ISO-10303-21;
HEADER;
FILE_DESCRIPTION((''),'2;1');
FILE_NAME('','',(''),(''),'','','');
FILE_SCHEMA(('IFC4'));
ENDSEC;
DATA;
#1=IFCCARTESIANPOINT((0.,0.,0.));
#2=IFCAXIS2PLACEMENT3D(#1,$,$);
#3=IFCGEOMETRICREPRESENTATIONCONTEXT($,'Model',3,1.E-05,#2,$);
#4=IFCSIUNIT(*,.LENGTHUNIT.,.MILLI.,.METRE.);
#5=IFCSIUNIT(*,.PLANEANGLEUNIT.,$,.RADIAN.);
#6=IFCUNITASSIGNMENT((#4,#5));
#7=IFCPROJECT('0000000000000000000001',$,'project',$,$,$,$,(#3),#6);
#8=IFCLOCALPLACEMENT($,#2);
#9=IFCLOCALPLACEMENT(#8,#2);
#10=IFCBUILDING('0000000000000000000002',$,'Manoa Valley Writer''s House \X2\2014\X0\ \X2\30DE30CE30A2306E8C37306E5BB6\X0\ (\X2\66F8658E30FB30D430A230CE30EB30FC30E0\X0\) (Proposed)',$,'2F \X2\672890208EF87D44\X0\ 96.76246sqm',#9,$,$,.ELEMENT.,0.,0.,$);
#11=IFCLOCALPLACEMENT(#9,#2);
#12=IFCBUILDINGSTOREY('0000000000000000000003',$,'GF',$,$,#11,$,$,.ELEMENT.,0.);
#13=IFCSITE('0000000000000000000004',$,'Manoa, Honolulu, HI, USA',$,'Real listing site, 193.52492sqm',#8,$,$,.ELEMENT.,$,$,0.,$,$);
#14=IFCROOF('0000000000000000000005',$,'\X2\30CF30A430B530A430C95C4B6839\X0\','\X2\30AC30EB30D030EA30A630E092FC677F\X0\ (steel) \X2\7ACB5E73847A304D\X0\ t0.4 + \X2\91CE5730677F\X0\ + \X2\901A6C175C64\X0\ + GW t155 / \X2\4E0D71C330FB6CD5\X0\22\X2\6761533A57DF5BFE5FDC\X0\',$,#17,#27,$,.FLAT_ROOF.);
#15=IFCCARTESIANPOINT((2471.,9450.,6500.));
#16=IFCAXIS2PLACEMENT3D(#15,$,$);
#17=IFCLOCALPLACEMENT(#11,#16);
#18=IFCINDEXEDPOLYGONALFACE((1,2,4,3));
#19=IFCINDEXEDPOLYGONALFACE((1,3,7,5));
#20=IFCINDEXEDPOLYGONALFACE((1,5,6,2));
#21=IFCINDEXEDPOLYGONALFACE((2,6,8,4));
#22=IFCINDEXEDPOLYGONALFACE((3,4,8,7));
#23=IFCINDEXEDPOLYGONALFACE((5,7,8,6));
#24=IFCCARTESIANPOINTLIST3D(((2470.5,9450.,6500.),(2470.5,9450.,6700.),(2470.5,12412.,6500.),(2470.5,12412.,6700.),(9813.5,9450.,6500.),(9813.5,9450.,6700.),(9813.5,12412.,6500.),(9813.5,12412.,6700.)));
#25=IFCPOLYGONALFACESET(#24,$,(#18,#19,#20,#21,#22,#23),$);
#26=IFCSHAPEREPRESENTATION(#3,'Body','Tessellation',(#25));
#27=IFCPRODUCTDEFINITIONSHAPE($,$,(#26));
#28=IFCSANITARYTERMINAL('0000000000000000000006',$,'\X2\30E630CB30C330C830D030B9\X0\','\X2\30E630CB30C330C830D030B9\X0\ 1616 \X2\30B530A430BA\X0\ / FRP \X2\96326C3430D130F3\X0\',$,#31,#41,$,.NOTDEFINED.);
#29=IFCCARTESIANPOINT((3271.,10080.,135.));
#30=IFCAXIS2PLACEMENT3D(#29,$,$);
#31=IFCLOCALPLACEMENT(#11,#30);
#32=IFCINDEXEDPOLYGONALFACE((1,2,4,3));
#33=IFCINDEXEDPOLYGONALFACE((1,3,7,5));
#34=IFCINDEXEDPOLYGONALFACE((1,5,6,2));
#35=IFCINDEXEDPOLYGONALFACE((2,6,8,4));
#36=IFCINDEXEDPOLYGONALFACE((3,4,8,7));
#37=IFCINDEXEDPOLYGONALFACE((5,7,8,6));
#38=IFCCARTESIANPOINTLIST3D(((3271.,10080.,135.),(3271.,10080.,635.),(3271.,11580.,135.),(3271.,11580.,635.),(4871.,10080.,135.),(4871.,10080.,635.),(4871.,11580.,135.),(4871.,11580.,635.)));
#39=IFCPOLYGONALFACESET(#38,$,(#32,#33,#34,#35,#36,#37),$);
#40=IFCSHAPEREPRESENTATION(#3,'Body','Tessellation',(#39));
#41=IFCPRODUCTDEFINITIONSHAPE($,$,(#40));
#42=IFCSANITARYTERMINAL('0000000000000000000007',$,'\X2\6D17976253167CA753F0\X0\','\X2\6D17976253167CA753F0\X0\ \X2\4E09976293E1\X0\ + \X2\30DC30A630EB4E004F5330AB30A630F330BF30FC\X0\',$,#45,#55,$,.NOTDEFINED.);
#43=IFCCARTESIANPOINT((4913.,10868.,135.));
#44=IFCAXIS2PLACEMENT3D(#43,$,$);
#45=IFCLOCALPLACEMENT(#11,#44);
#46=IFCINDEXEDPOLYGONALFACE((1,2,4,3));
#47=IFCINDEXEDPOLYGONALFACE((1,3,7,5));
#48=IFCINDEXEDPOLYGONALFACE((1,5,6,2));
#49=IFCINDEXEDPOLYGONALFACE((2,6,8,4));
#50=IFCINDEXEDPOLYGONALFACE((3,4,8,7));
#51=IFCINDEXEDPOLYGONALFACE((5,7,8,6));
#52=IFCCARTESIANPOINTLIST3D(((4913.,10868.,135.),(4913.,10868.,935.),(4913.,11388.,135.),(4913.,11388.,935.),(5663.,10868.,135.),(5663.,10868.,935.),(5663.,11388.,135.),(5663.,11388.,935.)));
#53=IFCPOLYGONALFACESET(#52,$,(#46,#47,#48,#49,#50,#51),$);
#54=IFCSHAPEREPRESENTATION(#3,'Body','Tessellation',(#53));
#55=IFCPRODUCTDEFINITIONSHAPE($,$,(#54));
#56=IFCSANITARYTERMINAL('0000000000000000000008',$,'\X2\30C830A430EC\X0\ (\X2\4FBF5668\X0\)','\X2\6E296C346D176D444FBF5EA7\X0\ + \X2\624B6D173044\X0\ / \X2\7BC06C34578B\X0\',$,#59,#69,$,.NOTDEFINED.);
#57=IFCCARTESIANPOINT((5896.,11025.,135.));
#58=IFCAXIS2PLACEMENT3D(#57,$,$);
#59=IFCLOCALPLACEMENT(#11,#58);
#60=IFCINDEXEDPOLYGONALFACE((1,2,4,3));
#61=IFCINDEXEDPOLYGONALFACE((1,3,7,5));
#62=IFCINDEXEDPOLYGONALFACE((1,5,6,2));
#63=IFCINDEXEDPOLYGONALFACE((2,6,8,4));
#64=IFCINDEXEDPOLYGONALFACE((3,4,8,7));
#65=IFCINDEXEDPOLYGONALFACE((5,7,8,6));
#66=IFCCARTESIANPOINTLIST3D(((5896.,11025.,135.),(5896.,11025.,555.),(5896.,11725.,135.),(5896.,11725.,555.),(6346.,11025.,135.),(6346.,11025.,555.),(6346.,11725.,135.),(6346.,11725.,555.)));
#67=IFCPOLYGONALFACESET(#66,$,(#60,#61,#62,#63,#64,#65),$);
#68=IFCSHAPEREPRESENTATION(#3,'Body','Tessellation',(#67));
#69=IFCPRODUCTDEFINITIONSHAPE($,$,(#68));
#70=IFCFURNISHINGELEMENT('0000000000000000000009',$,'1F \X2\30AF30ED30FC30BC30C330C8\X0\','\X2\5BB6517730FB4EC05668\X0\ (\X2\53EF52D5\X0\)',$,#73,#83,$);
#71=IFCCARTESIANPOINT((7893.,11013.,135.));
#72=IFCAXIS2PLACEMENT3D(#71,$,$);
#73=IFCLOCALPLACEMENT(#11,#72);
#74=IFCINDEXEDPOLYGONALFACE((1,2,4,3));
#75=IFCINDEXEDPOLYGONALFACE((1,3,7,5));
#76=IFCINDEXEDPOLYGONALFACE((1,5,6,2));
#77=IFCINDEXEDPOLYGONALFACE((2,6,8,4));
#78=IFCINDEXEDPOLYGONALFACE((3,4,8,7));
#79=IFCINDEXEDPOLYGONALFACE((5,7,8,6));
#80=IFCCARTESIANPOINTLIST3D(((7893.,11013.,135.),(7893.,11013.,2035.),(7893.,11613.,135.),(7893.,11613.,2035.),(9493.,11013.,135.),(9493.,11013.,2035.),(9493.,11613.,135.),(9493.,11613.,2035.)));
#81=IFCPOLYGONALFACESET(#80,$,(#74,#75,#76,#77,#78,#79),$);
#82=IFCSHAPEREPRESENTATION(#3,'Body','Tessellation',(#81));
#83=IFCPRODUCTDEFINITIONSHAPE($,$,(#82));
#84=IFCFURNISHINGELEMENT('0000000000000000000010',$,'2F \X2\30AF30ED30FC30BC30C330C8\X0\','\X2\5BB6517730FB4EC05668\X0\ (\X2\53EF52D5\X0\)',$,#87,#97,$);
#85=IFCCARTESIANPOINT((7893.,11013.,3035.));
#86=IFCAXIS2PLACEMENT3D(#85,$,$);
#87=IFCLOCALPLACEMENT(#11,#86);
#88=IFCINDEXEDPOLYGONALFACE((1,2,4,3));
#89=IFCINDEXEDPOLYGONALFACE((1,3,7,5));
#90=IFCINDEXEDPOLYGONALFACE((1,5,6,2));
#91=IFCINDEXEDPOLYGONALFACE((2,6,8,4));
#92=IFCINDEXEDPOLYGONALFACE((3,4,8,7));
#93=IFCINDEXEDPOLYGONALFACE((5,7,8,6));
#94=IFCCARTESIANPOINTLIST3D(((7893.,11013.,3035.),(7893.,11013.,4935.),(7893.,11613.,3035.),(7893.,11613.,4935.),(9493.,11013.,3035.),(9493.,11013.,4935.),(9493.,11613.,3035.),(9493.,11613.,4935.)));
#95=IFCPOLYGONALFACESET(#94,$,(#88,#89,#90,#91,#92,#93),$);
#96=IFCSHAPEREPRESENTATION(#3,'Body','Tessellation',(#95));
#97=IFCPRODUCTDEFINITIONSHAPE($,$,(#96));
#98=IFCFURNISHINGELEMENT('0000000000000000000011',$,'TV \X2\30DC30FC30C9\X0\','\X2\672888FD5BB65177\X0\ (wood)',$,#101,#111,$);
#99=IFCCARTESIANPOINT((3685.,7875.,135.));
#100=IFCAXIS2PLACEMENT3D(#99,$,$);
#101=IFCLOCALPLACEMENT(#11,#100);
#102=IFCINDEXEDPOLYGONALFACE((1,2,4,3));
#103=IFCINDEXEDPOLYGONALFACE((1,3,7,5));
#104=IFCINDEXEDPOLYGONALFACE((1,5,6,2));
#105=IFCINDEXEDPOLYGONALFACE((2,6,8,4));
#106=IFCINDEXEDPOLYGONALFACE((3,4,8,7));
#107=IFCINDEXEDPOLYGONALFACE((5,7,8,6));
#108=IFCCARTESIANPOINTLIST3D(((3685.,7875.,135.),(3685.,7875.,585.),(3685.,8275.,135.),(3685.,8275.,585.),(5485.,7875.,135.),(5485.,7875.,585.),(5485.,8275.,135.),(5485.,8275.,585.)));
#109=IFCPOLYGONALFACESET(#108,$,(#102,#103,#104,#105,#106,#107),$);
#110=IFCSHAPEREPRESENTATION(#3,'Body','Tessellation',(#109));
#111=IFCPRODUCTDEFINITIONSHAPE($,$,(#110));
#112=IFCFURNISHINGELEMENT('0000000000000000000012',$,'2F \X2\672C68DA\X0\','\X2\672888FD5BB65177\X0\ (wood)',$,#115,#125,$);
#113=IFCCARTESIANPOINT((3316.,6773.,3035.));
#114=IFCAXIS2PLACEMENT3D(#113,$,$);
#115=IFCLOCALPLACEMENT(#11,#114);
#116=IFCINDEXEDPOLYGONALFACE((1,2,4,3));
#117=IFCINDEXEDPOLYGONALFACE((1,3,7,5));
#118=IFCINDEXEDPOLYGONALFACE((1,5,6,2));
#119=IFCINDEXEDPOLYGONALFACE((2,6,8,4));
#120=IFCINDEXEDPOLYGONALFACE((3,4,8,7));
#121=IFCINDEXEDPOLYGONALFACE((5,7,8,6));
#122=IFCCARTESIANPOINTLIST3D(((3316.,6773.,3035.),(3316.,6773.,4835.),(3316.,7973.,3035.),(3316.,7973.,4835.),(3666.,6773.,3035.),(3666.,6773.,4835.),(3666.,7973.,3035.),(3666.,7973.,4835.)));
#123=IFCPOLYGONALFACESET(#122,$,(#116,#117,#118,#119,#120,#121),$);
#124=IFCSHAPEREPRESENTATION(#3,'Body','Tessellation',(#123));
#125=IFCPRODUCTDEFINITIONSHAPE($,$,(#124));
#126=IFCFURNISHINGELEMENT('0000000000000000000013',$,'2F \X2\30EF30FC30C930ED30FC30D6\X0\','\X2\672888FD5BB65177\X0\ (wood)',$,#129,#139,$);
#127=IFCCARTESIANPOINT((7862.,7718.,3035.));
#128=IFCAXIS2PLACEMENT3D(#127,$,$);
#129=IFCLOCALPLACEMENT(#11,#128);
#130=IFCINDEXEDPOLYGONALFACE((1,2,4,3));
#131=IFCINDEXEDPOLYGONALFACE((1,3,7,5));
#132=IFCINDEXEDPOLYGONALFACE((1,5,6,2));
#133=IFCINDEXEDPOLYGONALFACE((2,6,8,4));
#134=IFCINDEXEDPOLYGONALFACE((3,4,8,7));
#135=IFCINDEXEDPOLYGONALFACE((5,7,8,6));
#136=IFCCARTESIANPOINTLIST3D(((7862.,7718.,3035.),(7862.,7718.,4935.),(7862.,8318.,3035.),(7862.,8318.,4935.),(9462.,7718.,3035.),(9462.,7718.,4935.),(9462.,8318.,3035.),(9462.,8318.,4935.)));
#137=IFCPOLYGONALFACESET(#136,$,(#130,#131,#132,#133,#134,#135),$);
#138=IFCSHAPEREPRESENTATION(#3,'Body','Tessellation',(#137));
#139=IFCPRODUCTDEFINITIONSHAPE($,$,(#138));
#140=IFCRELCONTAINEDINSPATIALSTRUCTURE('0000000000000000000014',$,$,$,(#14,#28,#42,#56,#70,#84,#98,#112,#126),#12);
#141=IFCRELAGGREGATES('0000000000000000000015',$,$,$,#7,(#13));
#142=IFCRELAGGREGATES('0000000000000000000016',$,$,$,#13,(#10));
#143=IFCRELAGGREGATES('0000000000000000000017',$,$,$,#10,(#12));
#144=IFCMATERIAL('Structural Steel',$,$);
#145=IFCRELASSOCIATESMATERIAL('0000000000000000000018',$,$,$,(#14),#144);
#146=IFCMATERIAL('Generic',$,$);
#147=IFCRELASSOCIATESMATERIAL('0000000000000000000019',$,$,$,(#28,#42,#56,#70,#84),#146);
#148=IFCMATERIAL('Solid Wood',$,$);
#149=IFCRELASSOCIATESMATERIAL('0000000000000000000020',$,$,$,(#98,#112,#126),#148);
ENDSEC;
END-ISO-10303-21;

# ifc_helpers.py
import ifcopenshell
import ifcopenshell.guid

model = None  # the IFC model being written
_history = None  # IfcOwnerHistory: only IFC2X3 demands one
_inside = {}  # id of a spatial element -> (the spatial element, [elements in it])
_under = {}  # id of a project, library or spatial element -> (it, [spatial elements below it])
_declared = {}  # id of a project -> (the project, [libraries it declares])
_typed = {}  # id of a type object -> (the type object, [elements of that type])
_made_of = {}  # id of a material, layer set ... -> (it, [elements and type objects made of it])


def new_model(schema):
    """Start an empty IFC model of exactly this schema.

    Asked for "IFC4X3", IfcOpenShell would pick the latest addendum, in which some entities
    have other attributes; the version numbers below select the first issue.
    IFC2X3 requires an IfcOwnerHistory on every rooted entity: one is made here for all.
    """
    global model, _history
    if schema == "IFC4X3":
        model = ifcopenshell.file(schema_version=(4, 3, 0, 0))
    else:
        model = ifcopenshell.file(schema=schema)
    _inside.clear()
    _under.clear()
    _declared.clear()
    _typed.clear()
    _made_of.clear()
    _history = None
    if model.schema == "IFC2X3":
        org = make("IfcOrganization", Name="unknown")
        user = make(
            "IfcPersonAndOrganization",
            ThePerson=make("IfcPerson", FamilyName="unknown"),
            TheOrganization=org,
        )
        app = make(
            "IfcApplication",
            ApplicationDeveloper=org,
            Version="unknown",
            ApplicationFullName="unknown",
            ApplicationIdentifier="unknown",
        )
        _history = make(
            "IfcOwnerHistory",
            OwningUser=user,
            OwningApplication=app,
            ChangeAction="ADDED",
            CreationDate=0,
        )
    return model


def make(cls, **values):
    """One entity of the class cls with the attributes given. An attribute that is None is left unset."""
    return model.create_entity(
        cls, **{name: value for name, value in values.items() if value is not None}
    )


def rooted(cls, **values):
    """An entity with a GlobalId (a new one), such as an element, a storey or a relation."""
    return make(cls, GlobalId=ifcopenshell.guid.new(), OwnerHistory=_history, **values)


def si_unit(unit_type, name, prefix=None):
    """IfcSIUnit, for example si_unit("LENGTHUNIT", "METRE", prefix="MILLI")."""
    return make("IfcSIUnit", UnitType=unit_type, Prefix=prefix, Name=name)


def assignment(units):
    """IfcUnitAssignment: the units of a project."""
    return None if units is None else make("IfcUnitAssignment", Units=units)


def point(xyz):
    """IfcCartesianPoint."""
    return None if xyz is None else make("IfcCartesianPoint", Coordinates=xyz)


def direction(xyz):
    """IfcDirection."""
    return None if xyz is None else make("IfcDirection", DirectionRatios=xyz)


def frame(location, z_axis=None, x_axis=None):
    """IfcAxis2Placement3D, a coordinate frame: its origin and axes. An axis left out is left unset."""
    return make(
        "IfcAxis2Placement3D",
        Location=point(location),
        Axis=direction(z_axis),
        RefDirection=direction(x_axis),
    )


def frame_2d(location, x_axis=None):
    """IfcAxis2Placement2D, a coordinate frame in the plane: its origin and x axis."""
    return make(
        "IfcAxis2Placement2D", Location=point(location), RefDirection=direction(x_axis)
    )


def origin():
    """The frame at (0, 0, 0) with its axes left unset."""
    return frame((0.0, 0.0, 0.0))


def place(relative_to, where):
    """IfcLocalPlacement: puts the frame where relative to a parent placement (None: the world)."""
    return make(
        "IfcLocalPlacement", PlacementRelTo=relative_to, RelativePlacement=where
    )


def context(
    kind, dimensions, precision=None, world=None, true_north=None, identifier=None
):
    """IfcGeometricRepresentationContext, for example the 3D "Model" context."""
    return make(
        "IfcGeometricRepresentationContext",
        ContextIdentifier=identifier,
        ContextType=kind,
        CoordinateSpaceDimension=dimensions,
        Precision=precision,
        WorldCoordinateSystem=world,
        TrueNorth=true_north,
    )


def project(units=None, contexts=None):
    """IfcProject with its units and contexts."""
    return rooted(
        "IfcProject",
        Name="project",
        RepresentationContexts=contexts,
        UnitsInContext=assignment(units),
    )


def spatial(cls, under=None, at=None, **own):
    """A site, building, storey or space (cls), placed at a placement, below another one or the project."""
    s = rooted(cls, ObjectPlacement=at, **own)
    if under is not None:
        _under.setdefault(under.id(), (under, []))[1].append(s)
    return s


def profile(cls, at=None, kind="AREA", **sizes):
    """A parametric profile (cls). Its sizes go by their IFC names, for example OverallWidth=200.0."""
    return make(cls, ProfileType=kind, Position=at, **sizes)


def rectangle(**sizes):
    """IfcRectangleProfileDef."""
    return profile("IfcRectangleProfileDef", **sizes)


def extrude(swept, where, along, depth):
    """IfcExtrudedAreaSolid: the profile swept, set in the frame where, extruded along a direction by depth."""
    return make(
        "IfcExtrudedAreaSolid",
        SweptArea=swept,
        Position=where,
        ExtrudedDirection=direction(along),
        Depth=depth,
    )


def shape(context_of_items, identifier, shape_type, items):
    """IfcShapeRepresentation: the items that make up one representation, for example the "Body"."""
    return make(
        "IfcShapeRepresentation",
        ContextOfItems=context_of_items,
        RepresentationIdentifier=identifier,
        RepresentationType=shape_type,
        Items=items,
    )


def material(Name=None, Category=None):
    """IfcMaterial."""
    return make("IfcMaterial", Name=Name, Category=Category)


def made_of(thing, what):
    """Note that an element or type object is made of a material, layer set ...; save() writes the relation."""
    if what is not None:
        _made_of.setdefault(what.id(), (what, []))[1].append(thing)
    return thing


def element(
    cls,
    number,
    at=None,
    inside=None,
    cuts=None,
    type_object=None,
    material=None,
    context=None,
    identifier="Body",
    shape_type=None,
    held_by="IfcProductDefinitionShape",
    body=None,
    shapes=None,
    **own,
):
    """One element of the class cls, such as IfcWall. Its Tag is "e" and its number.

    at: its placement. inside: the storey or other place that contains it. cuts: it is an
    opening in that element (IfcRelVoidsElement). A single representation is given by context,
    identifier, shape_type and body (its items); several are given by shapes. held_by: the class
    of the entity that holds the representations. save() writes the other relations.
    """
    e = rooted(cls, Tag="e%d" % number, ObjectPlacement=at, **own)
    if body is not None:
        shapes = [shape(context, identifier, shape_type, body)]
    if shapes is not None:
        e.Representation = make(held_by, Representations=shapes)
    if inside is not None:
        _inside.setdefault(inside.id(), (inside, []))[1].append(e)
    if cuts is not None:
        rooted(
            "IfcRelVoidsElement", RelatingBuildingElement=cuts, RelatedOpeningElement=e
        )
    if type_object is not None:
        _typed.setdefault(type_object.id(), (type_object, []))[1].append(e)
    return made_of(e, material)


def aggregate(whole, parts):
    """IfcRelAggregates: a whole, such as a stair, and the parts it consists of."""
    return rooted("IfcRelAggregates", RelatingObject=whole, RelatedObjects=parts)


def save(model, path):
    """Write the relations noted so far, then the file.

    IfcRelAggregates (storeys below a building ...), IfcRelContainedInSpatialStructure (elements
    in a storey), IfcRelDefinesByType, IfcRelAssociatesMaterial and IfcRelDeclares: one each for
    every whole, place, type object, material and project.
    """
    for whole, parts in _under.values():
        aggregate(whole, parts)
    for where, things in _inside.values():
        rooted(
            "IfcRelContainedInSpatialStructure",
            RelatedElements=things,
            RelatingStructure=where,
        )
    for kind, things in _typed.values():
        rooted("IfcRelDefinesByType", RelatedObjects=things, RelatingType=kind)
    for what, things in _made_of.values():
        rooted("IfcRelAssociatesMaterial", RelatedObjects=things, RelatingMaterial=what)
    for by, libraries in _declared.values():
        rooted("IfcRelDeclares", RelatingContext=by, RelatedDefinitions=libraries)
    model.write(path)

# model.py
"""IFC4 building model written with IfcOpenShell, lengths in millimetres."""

from ifc_helpers import new_model, si_unit, frame, frame_2d, origin, place, context, project, spatial, rectangle, extrude, material, element, save


model = new_model("IFC4")

# Units and contexts
model_context = context("Model", 3, precision=1e-05, world=origin())
ifc_project = project(units=[si_unit("LENGTHUNIT", "METRE", prefix="MILLI"), si_unit("PLANEANGLEUNIT", "RADIAN")], contexts=[model_context])

# Site, building, storey
site_placement = place(None, origin())
site = spatial("IfcSite", under=ifc_project, at=site_placement, Name="Manoa, Honolulu, HI, USA", ObjectType="Real listing site, 193.52492sqm", CompositionType="ELEMENT", RefElevation=0.0)
building_placement = place(site_placement, origin())
building = spatial("IfcBuilding", under=site, at=building_placement, Name="Manoa Valley Writer's House — マノアの谷の家 (書斎・ピアノルーム) (Proposed)", ObjectType="2F 木造軸組 96.76246sqm", CompositionType="ELEMENT", ElevationOfRefHeight=0.0, ElevationOfTerrain=0.0)
storey_placement = place(building_placement, origin())
storey = spatial("IfcBuildingStorey", under=building, at=storey_placement, Name="GF", CompositionType="ELEMENT", Elevation=0.0)

# Shared definitions
ifc_material_1 = material(Name="Solid Wood")

# Roof
ifc_material_2 = material(Name="Structural Steel")
roof_placement = place(storey_placement, frame((2471.0, 9450.0, 6500.0)))
element("IfcRoof", 1, at=roof_placement, inside=storey, material=ifc_material_2, Name="ハイサイド屋根", Description="ガルバリウム鋼板 (steel) 立平葺き t0.4 + 野地板 + 通気層 + GW t155 / 不燃・法22条区域対応", PredefinedType="FLAT_ROOF", context=model_context, shape_type="SweptSolid", body=[
    extrude(rectangle(XDim=7343.0, YDim=2962.0, at=frame_2d((3671.0, 1481.0))), frame((2471.0, 9450.0, 6500.0)), (0.0, 0.0, 1.0), 200.0),
])

# Sanitary terminals
ifc_material_3 = material(Name="Generic")
sanitary_terminal_1_placement = place(storey_placement, frame((3271.0, 10080.0, 135.0)))
element("IfcSanitaryTerminal", 2, at=sanitary_terminal_1_placement, inside=storey, material=ifc_material_3, Name="ユニットバス", Description="ユニットバス 1616 サイズ / FRP 防水パン", PredefinedType="NOTDEFINED", context=model_context, shape_type="SweptSolid", body=[
    extrude(rectangle(XDim=1600.0, YDim=1500.0, at=frame_2d((800.0, 750.0))), frame((3271.0, 10080.0, 135.0)), (0.0, 0.0, 1.0), 500.0),
])
sanitary_terminal_2_placement = place(storey_placement, frame((4913.0, 10868.0, 135.0)))
element("IfcSanitaryTerminal", 3, at=sanitary_terminal_2_placement, inside=storey, material=ifc_material_3, Name="洗面化粧台", Description="洗面化粧台 三面鏡 + ボウル一体カウンター", PredefinedType="NOTDEFINED", context=model_context, shape_type="SweptSolid", body=[
    extrude(rectangle(XDim=750.0, YDim=520.0, at=frame_2d((375.0, 260.0))), frame((4913.0, 10868.0, 135.0)), (0.0, 0.0, 1.0), 800.0),
])
sanitary_terminal_3_placement = place(storey_placement, frame((5896.0, 11025.0, 135.0)))
element("IfcSanitaryTerminal", 4, at=sanitary_terminal_3_placement, inside=storey, material=ifc_material_3, Name="トイレ (便器)", Description="温水洗浄便座 + 手洗い / 節水型", PredefinedType="NOTDEFINED", context=model_context, shape_type="SweptSolid", body=[
    extrude(rectangle(XDim=450.0, YDim=700.0, at=frame_2d((225.0, 350.0))), frame((5896.0, 11025.0, 135.0)), (0.0, 0.0, 1.0), 420.0),
])

# Furnishing elements
furnishing_1_placement = place(storey_placement, frame((7893.0, 11013.0, 135.0)))
element("IfcFurnishingElement", 5, at=furnishing_1_placement, inside=storey, material=ifc_material_3, Name="1F クローゼット", Description="家具・什器 (可動)", context=model_context, shape_type="SweptSolid", body=[
    extrude(rectangle(XDim=1600.0, YDim=600.0, at=frame_2d((800.0, 300.0))), frame((7893.0, 11013.0, 135.0)), (0.0, 0.0, 1.0), 1900.0),
])
furnishing_2_placement = place(storey_placement, frame((7893.0, 11013.0, 3035.0)))
element("IfcFurnishingElement", 6, at=furnishing_2_placement, inside=storey, material=ifc_material_3, Name="2F クローゼット", Description="家具・什器 (可動)", context=model_context, shape_type="SweptSolid", body=[
    extrude(rectangle(XDim=1600.0, YDim=600.0, at=frame_2d((800.0, 300.0))), frame((7893.0, 11013.0, 3035.0)), (0.0, 0.0, 1.0), 1900.0),
])
furnishing_3_placement = place(storey_placement, frame((3685.0, 7875.0, 135.0)))
element("IfcFurnishingElement", 7, at=furnishing_3_placement, inside=storey, material=ifc_material_1, Name="TV ボード", Description="木製家具 (wood)", context=model_context, shape_type="SweptSolid", body=[
    extrude(rectangle(XDim=1800.0, YDim=400.0, at=frame_2d((900.0, 200.0))), frame((3685.0, 7875.0, 135.0)), (0.0, 0.0, 1.0), 450.0),
])
furnishing_4_placement = place(storey_placement, frame((3316.0, 6773.0, 3035.0)))
element("IfcFurnishingElement", 8, at=furnishing_4_placement, inside=storey, material=ifc_material_1, Name="2F 本棚", Description="木製家具 (wood)", context=model_context, shape_type="SweptSolid", body=[
    extrude(rectangle(XDim=350.0, YDim=1200.0, at=frame_2d((175.0, 600.0))), frame((3316.0, 6773.0, 3035.0)), (0.0, 0.0, 1.0), 1800.0),
])
furnishing_5_placement = place(storey_placement, frame((7862.0, 7718.0, 3035.0)))
element("IfcFurnishingElement", 9, at=furnishing_5_placement, inside=storey, material=ifc_material_1, Name="2F ワードローブ", Description="木製家具 (wood)", context=model_context, shape_type="SweptSolid", body=[
    extrude(rectangle(XDim=1600.0, YDim=600.0, at=frame_2d((800.0, 300.0))), frame((7862.0, 7718.0, 3035.0)), (0.0, 0.0, 1.0), 1900.0),
])

save(model, "model.ifc")
